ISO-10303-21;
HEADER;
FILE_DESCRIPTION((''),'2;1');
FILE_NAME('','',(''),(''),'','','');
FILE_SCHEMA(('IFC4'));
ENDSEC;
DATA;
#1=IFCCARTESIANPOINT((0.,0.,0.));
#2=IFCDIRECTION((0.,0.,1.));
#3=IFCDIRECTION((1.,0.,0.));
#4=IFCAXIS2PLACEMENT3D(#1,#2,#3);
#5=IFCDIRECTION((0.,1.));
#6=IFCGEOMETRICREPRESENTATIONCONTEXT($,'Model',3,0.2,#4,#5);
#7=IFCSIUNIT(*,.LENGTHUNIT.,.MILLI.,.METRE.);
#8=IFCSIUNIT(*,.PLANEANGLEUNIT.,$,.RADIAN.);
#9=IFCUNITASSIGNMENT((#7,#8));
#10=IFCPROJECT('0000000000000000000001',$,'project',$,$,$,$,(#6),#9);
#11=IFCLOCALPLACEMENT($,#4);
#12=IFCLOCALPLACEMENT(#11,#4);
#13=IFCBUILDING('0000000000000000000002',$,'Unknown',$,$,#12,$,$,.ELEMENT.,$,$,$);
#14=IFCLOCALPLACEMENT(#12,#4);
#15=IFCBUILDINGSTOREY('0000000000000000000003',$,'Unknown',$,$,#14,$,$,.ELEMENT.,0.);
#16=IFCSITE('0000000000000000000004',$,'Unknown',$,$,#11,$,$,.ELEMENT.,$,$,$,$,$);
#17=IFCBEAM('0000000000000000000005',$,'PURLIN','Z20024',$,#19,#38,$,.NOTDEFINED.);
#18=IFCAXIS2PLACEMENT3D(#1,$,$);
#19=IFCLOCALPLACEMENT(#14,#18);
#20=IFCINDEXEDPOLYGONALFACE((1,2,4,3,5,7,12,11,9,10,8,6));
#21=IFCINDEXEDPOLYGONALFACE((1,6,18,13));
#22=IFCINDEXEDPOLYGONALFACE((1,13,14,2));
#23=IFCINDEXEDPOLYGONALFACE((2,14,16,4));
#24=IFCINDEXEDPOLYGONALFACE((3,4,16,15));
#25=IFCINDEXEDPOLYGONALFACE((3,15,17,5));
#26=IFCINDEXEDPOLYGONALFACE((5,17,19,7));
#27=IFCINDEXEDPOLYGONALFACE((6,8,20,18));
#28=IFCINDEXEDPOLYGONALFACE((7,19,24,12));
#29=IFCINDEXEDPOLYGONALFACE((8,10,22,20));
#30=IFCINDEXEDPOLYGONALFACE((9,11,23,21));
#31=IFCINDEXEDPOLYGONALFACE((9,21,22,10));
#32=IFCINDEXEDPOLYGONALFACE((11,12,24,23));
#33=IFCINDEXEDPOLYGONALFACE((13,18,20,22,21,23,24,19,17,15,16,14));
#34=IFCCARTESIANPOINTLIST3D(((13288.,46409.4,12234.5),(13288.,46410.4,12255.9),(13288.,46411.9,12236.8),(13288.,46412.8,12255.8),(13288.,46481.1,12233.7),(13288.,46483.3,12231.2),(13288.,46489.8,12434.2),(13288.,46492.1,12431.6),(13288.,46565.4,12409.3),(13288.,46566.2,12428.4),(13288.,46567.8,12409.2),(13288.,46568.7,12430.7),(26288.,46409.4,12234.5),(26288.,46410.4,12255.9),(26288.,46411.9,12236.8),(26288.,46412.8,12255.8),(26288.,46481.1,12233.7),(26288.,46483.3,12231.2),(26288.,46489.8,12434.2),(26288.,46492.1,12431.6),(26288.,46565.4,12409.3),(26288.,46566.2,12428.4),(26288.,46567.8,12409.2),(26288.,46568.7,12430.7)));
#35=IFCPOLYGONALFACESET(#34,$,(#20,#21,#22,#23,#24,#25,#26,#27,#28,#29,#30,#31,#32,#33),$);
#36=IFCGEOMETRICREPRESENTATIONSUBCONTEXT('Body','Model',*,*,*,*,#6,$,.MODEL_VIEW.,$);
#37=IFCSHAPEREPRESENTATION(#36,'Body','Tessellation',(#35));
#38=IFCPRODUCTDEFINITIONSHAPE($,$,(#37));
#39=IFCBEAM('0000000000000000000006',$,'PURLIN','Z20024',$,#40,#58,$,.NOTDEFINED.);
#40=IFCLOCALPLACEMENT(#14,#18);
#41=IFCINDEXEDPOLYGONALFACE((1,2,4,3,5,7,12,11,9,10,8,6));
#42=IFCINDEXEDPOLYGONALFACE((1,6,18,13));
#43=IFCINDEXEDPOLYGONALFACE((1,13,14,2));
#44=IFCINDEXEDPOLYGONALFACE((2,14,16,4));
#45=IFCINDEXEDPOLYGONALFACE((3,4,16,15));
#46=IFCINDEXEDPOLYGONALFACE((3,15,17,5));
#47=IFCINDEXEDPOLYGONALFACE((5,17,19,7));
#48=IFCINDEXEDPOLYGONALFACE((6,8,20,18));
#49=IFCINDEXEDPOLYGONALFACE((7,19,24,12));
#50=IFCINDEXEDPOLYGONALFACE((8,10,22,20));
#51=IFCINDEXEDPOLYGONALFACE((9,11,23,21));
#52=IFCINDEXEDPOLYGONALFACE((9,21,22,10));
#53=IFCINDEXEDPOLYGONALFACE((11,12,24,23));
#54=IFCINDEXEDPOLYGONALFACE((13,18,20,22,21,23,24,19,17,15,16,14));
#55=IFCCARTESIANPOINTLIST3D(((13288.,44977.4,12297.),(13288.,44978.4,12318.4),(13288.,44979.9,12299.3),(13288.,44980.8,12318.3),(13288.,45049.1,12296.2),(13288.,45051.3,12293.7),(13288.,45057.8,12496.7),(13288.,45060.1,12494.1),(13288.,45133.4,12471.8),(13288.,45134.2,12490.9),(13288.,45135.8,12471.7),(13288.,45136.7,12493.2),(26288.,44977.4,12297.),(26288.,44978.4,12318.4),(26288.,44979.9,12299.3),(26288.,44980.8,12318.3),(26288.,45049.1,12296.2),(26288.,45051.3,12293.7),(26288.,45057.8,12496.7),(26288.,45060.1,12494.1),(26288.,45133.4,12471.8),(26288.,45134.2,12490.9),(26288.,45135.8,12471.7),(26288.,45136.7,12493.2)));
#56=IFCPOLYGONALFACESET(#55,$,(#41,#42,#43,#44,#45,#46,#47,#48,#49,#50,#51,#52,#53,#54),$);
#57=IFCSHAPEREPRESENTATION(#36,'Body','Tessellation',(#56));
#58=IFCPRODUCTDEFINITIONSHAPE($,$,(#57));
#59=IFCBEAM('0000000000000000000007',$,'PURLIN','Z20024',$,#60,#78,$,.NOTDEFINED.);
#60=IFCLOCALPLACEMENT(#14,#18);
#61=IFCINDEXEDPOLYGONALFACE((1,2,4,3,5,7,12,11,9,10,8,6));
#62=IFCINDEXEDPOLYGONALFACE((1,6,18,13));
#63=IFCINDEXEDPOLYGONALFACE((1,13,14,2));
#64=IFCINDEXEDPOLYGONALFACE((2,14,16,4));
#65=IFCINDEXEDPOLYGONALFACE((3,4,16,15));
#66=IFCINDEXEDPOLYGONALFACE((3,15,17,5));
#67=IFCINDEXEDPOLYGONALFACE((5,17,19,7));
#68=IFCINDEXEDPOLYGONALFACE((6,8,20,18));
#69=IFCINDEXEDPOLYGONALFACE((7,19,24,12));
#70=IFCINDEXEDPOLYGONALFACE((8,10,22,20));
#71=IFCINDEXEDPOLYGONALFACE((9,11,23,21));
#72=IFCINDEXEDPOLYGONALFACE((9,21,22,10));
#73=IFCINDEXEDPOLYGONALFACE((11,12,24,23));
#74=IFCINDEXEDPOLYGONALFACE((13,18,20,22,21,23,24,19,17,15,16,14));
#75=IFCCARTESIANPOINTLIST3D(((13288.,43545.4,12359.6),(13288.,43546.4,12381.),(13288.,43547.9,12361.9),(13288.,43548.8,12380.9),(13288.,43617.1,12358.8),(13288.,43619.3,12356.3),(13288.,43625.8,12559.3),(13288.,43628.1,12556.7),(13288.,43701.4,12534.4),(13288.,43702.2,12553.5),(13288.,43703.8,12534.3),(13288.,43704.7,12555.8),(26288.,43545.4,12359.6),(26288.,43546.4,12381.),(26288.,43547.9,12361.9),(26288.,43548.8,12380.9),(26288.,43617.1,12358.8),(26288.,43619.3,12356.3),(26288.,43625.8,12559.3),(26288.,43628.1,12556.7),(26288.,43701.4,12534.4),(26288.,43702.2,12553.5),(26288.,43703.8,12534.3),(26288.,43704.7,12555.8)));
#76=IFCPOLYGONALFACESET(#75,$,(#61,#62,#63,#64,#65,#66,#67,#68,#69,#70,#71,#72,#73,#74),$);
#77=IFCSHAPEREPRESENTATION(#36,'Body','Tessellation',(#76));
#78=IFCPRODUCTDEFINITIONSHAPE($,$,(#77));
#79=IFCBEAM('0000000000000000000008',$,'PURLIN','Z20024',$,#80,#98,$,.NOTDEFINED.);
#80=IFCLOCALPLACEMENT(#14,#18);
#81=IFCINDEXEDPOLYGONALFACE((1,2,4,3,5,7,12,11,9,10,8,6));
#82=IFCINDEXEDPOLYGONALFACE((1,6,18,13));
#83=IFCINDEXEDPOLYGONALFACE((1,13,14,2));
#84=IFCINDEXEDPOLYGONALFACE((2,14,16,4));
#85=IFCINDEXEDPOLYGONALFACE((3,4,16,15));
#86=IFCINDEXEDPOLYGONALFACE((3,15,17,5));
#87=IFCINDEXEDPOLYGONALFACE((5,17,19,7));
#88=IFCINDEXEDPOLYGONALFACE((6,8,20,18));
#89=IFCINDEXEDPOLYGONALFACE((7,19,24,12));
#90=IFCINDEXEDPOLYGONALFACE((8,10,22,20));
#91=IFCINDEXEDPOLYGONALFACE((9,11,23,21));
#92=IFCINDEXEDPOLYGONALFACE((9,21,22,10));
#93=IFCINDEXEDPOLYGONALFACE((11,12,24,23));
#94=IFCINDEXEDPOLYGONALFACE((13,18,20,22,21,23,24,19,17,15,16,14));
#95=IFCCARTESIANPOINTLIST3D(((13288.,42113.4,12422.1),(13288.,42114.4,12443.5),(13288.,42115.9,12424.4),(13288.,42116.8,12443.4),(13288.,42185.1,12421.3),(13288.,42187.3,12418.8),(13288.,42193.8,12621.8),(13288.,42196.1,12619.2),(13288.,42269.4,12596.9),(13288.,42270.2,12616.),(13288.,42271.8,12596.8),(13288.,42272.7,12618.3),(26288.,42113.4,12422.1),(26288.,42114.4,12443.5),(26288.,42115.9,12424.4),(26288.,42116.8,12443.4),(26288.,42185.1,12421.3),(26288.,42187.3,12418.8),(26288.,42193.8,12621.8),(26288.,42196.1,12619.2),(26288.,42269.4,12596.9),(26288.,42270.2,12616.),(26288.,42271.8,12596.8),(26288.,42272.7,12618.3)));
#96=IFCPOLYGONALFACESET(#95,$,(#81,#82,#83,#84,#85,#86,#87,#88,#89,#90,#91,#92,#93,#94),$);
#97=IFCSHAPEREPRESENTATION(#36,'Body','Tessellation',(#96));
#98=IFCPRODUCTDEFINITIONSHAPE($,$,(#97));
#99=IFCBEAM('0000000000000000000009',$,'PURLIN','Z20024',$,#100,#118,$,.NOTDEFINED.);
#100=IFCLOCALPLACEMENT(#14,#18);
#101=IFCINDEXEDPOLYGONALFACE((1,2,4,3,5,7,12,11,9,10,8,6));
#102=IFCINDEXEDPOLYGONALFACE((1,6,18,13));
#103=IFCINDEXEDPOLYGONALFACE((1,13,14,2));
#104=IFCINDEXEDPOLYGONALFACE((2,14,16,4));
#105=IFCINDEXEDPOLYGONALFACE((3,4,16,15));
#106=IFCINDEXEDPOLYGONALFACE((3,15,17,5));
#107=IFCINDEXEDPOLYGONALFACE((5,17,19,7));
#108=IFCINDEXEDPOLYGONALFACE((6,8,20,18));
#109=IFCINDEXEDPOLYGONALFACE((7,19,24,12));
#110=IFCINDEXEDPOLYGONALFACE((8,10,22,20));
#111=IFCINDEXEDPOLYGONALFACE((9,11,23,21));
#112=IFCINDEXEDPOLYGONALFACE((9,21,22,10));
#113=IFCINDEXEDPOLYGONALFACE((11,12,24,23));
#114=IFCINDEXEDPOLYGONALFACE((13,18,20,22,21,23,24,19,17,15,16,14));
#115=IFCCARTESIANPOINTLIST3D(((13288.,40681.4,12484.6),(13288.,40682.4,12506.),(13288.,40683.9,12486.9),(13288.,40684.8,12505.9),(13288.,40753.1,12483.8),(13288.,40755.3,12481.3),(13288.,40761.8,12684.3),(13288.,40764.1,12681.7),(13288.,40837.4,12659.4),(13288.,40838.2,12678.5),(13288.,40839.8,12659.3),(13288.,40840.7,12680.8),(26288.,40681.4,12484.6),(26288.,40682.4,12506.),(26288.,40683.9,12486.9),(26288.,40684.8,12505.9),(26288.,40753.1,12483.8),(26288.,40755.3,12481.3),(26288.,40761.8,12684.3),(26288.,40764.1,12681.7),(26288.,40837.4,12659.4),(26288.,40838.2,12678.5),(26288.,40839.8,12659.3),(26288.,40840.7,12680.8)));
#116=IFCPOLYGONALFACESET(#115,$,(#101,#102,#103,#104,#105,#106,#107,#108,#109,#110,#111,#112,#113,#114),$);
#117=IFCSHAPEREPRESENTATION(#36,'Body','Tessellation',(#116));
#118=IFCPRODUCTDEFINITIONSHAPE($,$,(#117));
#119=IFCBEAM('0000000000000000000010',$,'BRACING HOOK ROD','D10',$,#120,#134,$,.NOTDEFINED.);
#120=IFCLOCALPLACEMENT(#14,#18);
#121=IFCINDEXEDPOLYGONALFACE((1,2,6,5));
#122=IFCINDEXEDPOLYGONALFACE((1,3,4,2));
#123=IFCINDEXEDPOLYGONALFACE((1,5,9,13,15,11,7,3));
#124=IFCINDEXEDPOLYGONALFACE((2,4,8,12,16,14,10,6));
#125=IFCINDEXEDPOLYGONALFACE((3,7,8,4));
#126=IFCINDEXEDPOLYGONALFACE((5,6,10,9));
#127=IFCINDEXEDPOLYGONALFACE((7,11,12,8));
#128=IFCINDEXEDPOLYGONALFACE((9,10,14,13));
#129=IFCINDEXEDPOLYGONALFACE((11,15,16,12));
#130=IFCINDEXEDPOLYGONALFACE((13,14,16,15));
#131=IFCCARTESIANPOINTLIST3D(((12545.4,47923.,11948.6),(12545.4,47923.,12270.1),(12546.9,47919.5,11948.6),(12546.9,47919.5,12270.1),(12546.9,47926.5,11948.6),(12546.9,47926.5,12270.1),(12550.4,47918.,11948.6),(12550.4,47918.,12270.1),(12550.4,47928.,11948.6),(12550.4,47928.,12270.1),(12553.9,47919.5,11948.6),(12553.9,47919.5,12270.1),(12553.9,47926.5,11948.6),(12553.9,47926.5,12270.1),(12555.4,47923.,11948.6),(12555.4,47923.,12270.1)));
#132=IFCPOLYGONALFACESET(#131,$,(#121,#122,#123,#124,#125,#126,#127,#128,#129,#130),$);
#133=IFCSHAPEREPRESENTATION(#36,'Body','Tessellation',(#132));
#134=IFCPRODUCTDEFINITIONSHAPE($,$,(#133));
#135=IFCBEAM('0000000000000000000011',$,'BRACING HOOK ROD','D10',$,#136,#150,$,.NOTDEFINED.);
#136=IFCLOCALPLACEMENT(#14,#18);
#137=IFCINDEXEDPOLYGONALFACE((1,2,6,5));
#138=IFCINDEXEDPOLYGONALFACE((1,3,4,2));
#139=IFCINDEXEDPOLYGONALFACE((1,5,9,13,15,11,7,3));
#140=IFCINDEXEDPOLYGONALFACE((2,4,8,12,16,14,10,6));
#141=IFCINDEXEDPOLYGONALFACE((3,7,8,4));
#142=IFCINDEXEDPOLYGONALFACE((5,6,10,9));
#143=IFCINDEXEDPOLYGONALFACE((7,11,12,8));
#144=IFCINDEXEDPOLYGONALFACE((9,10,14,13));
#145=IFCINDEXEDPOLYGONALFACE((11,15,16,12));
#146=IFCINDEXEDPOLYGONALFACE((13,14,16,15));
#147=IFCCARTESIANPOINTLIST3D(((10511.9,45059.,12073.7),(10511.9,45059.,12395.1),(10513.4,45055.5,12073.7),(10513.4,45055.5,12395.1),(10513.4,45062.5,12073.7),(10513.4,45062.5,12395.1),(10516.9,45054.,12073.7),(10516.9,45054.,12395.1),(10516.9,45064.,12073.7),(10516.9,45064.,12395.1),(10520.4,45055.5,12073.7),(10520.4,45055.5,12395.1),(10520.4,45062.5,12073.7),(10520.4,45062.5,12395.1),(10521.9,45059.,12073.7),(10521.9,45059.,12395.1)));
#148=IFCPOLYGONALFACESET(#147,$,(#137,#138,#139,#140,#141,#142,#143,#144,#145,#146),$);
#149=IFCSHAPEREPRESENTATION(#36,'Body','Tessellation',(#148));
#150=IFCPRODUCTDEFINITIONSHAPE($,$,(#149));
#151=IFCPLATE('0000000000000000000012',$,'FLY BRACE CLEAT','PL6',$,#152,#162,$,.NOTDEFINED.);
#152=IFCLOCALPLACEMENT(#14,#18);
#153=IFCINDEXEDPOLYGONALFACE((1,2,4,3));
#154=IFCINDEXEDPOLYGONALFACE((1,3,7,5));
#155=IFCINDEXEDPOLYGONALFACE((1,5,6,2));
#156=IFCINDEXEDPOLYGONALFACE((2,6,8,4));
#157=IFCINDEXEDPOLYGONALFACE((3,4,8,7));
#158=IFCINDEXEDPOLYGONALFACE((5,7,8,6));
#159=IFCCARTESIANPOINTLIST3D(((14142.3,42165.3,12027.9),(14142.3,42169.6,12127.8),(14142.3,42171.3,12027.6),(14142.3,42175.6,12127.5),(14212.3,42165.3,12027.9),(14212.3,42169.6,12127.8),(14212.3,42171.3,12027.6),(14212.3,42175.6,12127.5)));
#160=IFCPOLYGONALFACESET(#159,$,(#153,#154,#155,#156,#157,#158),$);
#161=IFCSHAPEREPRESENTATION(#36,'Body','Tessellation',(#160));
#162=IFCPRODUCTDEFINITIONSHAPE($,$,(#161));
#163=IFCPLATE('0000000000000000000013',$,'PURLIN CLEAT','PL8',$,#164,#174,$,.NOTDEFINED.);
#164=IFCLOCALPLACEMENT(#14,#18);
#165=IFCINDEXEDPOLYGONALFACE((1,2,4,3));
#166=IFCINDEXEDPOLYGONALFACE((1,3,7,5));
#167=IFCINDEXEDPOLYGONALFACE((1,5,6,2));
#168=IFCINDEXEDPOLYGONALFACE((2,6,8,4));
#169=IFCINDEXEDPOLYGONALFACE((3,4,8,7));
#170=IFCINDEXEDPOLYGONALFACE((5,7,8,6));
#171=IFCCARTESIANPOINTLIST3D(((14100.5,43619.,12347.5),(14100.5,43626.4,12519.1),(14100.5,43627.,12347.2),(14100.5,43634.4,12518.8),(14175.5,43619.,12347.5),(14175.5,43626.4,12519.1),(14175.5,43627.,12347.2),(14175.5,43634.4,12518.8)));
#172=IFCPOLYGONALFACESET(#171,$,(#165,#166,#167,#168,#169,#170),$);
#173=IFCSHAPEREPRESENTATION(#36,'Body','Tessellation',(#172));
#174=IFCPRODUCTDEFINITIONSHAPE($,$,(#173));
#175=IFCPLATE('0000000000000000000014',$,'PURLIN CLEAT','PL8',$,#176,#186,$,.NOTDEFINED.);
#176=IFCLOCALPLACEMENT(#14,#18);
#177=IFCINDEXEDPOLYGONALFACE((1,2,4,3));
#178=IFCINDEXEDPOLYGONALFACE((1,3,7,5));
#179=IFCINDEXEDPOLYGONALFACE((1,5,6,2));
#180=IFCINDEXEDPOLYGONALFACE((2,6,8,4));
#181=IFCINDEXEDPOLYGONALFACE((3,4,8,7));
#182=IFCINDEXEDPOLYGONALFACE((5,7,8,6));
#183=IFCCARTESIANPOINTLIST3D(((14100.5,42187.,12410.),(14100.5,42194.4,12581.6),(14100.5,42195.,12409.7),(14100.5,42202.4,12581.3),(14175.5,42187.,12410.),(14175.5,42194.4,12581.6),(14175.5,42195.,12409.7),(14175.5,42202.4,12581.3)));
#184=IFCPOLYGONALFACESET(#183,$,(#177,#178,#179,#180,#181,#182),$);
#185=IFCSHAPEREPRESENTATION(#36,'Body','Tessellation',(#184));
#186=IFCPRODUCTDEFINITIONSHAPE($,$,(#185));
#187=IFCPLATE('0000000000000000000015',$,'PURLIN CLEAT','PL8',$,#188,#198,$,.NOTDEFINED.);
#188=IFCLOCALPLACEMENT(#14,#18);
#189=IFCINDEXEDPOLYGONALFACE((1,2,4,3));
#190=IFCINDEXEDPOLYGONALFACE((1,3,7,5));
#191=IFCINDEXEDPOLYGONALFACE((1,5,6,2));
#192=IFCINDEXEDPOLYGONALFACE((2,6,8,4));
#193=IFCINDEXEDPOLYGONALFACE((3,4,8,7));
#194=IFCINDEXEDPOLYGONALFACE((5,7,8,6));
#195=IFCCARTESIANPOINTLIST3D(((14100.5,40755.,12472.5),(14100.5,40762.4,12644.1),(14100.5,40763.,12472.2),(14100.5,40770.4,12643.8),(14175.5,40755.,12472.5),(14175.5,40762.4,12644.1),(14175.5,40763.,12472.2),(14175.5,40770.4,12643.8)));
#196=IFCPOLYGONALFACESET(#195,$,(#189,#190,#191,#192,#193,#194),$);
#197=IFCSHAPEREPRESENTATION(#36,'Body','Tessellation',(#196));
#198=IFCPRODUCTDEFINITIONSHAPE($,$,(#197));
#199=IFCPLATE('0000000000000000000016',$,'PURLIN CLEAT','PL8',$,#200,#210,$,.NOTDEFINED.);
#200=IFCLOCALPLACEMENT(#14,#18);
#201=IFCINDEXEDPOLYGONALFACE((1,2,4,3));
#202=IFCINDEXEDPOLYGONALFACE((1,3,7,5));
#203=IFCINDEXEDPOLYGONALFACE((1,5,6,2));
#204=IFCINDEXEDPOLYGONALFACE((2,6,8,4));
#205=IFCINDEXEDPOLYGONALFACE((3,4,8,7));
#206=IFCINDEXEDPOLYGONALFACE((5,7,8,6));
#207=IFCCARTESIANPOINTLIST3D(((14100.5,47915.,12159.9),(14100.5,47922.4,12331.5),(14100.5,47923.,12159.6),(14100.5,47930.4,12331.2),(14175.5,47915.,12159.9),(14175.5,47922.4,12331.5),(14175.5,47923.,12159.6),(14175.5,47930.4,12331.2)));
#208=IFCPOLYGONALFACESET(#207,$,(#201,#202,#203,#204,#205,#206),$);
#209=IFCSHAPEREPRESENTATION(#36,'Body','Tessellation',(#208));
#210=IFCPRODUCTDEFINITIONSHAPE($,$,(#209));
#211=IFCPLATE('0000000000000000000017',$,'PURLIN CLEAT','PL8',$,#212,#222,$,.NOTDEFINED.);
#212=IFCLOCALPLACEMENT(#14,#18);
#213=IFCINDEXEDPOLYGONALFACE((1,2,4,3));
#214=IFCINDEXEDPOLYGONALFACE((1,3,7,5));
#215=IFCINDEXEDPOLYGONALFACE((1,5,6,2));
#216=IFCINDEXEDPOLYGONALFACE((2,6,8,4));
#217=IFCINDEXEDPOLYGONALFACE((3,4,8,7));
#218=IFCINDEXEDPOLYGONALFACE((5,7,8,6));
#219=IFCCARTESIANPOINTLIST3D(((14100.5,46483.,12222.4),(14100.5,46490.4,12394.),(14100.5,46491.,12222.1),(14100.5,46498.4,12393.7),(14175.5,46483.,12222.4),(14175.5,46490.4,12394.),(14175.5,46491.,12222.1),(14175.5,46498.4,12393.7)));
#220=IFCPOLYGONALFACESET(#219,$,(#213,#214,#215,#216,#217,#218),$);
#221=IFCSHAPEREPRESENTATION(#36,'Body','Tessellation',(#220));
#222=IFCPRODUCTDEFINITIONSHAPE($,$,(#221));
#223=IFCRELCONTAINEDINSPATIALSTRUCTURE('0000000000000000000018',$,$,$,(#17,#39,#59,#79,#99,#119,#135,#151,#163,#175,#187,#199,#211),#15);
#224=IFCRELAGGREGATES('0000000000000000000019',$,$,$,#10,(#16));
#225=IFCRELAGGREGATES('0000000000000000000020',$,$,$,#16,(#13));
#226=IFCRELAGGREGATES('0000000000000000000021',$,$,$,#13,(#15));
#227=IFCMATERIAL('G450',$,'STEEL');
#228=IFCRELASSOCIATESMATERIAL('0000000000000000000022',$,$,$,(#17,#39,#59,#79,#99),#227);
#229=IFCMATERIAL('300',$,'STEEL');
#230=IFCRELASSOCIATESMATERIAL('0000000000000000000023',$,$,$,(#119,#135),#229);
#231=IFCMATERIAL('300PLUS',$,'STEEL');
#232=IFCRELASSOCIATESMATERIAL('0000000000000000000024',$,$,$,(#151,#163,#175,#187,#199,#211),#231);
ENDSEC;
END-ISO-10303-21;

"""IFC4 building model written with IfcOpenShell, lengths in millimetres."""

from ifc_helpers import new_model, si_unit, direction, frame, origin_with_axes, place, context, subcontext, project, spatial, line, indexed_curve, outline, extrude, material, element, save


model = new_model("IFC4")

# Units and contexts
model_context = context("Model", 3, precision=0.2, world=origin_with_axes(), true_north=direction((0.0, 1.0)))
body_context = subcontext(model_context, "Body", "Model", "MODEL_VIEW")
ifc_project = project(units=[si_unit("LENGTHUNIT", "METRE", prefix="MILLI"), si_unit("PLANEANGLEUNIT", "RADIAN")], contexts=[model_context])

# Site, building, storey
site_placement = place(None, origin_with_axes())
site = spatial("IfcSite", under=ifc_project, at=site_placement, Name="Unknown", CompositionType="ELEMENT")
building_placement = place(site_placement, origin_with_axes())
building = spatial("IfcBuilding", under=site, at=building_placement, Name="Unknown", CompositionType="ELEMENT")
storey_placement = place(building_placement, origin_with_axes())
storey = spatial("IfcBuildingStorey", under=building, at=storey_placement, Name="Unknown", CompositionType="ELEMENT", Elevation=0.0)

# Beams
ifc_material_1 = material(Name="G450", Category="STEEL")
for number, where, z_axis, x_axis, name in (
    (1, (13288.0, 46486.6, 12332.7), (0.0, -0.999048, 0.043619), (1.0, 0.0, 0.0), "PURLIN"),
    (2, (13288.0, 45054.6, 12395.2), (0.0, -0.999048, 0.043619), (1.0, 0.0, 0.0), "PURLIN"),
    (3, (13288.0, 43622.6, 12457.8), (0.0, -0.999048, 0.043619), (1.0, 0.0, 0.0), "PURLIN"),
    (4, (13288.0, 42190.6, 12520.3), (0.0, -0.999048, 0.043619), (1.0, 0.0, 0.0), "PURLIN"),
    (5, (13288.0, 40758.6, 12582.8), (0.0, -0.999048, 0.043619), (1.0, 0.0, 0.0), "PURLIN"),
):
    element("IfcBeam", number, at=place(storey_placement, frame(where, z_axis=z_axis, x_axis=x_axis)), inside=storey, material=ifc_material_1, Name=name, Description="Z20024", PredefinedType="NOTDEFINED", context=body_context, shape_type="SolidModel", body=[
        extrude(outline(indexed_curve([(72.8, -101.5), (72.8, -80.0), (70.4, -80.0), (70.4, -99.1), (1.2, -99.1), (1.2, 101.5), (-77.8, 101.5), (-77.8, 80.0), (-75.4, 80.0), (-75.4, 99.1), (-1.2, 99.1), (-1.2, -101.5)], segments=[line(1, 2, 3, 4, 5, 6, 7, 8, 9, 10, 11, 12, 1)])), frame((0.0, 0.0, 0.0), z_axis=(-1.0, 0.0, 0.0), x_axis=(0.0, 0.0, 1.0)), (0.0, 0.0, -1.0), 13000.0),
    ])
ifc_material_2 = material(Name="300", Category="STEEL")
beam_1_placement = place(storey_placement, frame((12550.4, 47923.0, 12270.1), z_axis=(1.0, 0.0, 0.0), x_axis=(0.0, 0.0, -1.0)))
element("IfcBeam", 6, at=beam_1_placement, inside=storey, material=ifc_material_2, Name="BRACING HOOK ROD", Description="D10", PredefinedType="NOTDEFINED", context=body_context, shape_type="SolidModel", body=[
    extrude(outline(indexed_curve([(5.0, 0.0), (3.5, 3.5), (0.0, 5.0), (-3.5, 3.5), (-5.0, 0.0), (-3.5, -3.5), (0.0, -5.0), (3.5, -3.5)], segments=[line(1, 2, 3, 4, 5, 6, 7, 8, 1)])), frame((0.0, 0.0, 0.0), z_axis=(-1.0, 0.0, 0.0), x_axis=(0.0, 0.0, 1.0)), (0.0, 0.0, -1.0), 321.5),
])
beam_2_placement = place(storey_placement, frame((10516.9, 45059.0, 12395.1), z_axis=(1.0, 0.0, 0.0), x_axis=(0.0, 0.0, -1.0)))
element("IfcBeam", 7, at=beam_2_placement, inside=storey, material=ifc_material_2, Name="BRACING HOOK ROD", Description="D10", PredefinedType="NOTDEFINED", context=body_context, shape_type="SolidModel", body=[
    extrude(outline(indexed_curve([(5.0, 0.0), (3.5, 3.5), (0.0, 5.0), (-3.5, 3.5), (-5.0, 0.0), (-3.5, -3.5), (0.0, -5.0), (3.5, -3.5)], segments=[line(1, 2, 3, 4, 5, 6, 7, 8, 1)])), frame((0.0, 0.0, 0.0), z_axis=(-1.0, 0.0, 0.0), x_axis=(0.0, 0.0, 1.0)), (0.0, 0.0, -1.0), 321.4),
])

# Plates
ifc_material_3 = material(Name="300PLUS", Category="STEEL")
plate_1_placement = place(storey_placement, frame((14212.3, 42172.6, 12127.6), z_axis=(0.0, -0.999075, 0.043003), x_axis=(-1.0, 0.0, 0.0)))
element("IfcPlate", 8, at=plate_1_placement, inside=storey, material=ifc_material_3, Name="FLY BRACE CLEAT", Description="PL6", PredefinedType="NOTDEFINED", context=body_context, shape_type="SolidModel", body=[
    extrude(outline(indexed_curve([(0.0, 0.0), (70.0, 0.0), (70.0, 100.0), (0.0, 100.0)], segments=[line(1, 2, 3, 4, 1)])), frame((0.0, 0.0, 3.0), z_axis=(0.0, 0.0, 1.0), x_axis=(1.0, 0.0, 0.0)), (0.0, 0.0, -1.0), 6.0),
])
for number, where, z_axis, x_axis, name in (
    (9, (14100.5, 43623.0, 12347.4), (0.0, -0.999071, 0.043084), (1.0, 0.0, 0.0), "PURLIN CLEAT"),
    (10, (14100.5, 42191.0, 12409.9), (0.0, -0.999071, 0.043084), (1.0, 0.0, 0.0), "PURLIN CLEAT"),
    (11, (14100.5, 40759.0, 12472.4), (0.0, -0.999071, 0.043084), (1.0, 0.0, 0.0), "PURLIN CLEAT"),
    (12, (14100.5, 47919.0, 12159.8), (0.0, -0.999071, 0.043084), (1.0, 0.0, 0.0), "PURLIN CLEAT"),
    (13, (14100.5, 46487.0, 12222.3), (0.0, -0.999071, 0.043084), (1.0, 0.0, 0.0), "PURLIN CLEAT"),
):
    element("IfcPlate", number, at=place(storey_placement, frame(where, z_axis=z_axis, x_axis=x_axis)), inside=storey, material=ifc_material_3, Name=name, Description="PL8", PredefinedType="NOTDEFINED", context=body_context, shape_type="SolidModel", body=[
        extrude(outline(indexed_curve([(0.0, 0.0), (75.0, 0.0), (75.0, 171.8), (0.0, 171.8)], segments=[line(1, 2, 3, 4, 1)])), frame((0.0, 0.0, 4.0), z_axis=(0.0, 0.0, 1.0), x_axis=(1.0, 0.0, 0.0)), (0.0, 0.0, -1.0), 8.0),
    ])

save(model, "model.ifc")
